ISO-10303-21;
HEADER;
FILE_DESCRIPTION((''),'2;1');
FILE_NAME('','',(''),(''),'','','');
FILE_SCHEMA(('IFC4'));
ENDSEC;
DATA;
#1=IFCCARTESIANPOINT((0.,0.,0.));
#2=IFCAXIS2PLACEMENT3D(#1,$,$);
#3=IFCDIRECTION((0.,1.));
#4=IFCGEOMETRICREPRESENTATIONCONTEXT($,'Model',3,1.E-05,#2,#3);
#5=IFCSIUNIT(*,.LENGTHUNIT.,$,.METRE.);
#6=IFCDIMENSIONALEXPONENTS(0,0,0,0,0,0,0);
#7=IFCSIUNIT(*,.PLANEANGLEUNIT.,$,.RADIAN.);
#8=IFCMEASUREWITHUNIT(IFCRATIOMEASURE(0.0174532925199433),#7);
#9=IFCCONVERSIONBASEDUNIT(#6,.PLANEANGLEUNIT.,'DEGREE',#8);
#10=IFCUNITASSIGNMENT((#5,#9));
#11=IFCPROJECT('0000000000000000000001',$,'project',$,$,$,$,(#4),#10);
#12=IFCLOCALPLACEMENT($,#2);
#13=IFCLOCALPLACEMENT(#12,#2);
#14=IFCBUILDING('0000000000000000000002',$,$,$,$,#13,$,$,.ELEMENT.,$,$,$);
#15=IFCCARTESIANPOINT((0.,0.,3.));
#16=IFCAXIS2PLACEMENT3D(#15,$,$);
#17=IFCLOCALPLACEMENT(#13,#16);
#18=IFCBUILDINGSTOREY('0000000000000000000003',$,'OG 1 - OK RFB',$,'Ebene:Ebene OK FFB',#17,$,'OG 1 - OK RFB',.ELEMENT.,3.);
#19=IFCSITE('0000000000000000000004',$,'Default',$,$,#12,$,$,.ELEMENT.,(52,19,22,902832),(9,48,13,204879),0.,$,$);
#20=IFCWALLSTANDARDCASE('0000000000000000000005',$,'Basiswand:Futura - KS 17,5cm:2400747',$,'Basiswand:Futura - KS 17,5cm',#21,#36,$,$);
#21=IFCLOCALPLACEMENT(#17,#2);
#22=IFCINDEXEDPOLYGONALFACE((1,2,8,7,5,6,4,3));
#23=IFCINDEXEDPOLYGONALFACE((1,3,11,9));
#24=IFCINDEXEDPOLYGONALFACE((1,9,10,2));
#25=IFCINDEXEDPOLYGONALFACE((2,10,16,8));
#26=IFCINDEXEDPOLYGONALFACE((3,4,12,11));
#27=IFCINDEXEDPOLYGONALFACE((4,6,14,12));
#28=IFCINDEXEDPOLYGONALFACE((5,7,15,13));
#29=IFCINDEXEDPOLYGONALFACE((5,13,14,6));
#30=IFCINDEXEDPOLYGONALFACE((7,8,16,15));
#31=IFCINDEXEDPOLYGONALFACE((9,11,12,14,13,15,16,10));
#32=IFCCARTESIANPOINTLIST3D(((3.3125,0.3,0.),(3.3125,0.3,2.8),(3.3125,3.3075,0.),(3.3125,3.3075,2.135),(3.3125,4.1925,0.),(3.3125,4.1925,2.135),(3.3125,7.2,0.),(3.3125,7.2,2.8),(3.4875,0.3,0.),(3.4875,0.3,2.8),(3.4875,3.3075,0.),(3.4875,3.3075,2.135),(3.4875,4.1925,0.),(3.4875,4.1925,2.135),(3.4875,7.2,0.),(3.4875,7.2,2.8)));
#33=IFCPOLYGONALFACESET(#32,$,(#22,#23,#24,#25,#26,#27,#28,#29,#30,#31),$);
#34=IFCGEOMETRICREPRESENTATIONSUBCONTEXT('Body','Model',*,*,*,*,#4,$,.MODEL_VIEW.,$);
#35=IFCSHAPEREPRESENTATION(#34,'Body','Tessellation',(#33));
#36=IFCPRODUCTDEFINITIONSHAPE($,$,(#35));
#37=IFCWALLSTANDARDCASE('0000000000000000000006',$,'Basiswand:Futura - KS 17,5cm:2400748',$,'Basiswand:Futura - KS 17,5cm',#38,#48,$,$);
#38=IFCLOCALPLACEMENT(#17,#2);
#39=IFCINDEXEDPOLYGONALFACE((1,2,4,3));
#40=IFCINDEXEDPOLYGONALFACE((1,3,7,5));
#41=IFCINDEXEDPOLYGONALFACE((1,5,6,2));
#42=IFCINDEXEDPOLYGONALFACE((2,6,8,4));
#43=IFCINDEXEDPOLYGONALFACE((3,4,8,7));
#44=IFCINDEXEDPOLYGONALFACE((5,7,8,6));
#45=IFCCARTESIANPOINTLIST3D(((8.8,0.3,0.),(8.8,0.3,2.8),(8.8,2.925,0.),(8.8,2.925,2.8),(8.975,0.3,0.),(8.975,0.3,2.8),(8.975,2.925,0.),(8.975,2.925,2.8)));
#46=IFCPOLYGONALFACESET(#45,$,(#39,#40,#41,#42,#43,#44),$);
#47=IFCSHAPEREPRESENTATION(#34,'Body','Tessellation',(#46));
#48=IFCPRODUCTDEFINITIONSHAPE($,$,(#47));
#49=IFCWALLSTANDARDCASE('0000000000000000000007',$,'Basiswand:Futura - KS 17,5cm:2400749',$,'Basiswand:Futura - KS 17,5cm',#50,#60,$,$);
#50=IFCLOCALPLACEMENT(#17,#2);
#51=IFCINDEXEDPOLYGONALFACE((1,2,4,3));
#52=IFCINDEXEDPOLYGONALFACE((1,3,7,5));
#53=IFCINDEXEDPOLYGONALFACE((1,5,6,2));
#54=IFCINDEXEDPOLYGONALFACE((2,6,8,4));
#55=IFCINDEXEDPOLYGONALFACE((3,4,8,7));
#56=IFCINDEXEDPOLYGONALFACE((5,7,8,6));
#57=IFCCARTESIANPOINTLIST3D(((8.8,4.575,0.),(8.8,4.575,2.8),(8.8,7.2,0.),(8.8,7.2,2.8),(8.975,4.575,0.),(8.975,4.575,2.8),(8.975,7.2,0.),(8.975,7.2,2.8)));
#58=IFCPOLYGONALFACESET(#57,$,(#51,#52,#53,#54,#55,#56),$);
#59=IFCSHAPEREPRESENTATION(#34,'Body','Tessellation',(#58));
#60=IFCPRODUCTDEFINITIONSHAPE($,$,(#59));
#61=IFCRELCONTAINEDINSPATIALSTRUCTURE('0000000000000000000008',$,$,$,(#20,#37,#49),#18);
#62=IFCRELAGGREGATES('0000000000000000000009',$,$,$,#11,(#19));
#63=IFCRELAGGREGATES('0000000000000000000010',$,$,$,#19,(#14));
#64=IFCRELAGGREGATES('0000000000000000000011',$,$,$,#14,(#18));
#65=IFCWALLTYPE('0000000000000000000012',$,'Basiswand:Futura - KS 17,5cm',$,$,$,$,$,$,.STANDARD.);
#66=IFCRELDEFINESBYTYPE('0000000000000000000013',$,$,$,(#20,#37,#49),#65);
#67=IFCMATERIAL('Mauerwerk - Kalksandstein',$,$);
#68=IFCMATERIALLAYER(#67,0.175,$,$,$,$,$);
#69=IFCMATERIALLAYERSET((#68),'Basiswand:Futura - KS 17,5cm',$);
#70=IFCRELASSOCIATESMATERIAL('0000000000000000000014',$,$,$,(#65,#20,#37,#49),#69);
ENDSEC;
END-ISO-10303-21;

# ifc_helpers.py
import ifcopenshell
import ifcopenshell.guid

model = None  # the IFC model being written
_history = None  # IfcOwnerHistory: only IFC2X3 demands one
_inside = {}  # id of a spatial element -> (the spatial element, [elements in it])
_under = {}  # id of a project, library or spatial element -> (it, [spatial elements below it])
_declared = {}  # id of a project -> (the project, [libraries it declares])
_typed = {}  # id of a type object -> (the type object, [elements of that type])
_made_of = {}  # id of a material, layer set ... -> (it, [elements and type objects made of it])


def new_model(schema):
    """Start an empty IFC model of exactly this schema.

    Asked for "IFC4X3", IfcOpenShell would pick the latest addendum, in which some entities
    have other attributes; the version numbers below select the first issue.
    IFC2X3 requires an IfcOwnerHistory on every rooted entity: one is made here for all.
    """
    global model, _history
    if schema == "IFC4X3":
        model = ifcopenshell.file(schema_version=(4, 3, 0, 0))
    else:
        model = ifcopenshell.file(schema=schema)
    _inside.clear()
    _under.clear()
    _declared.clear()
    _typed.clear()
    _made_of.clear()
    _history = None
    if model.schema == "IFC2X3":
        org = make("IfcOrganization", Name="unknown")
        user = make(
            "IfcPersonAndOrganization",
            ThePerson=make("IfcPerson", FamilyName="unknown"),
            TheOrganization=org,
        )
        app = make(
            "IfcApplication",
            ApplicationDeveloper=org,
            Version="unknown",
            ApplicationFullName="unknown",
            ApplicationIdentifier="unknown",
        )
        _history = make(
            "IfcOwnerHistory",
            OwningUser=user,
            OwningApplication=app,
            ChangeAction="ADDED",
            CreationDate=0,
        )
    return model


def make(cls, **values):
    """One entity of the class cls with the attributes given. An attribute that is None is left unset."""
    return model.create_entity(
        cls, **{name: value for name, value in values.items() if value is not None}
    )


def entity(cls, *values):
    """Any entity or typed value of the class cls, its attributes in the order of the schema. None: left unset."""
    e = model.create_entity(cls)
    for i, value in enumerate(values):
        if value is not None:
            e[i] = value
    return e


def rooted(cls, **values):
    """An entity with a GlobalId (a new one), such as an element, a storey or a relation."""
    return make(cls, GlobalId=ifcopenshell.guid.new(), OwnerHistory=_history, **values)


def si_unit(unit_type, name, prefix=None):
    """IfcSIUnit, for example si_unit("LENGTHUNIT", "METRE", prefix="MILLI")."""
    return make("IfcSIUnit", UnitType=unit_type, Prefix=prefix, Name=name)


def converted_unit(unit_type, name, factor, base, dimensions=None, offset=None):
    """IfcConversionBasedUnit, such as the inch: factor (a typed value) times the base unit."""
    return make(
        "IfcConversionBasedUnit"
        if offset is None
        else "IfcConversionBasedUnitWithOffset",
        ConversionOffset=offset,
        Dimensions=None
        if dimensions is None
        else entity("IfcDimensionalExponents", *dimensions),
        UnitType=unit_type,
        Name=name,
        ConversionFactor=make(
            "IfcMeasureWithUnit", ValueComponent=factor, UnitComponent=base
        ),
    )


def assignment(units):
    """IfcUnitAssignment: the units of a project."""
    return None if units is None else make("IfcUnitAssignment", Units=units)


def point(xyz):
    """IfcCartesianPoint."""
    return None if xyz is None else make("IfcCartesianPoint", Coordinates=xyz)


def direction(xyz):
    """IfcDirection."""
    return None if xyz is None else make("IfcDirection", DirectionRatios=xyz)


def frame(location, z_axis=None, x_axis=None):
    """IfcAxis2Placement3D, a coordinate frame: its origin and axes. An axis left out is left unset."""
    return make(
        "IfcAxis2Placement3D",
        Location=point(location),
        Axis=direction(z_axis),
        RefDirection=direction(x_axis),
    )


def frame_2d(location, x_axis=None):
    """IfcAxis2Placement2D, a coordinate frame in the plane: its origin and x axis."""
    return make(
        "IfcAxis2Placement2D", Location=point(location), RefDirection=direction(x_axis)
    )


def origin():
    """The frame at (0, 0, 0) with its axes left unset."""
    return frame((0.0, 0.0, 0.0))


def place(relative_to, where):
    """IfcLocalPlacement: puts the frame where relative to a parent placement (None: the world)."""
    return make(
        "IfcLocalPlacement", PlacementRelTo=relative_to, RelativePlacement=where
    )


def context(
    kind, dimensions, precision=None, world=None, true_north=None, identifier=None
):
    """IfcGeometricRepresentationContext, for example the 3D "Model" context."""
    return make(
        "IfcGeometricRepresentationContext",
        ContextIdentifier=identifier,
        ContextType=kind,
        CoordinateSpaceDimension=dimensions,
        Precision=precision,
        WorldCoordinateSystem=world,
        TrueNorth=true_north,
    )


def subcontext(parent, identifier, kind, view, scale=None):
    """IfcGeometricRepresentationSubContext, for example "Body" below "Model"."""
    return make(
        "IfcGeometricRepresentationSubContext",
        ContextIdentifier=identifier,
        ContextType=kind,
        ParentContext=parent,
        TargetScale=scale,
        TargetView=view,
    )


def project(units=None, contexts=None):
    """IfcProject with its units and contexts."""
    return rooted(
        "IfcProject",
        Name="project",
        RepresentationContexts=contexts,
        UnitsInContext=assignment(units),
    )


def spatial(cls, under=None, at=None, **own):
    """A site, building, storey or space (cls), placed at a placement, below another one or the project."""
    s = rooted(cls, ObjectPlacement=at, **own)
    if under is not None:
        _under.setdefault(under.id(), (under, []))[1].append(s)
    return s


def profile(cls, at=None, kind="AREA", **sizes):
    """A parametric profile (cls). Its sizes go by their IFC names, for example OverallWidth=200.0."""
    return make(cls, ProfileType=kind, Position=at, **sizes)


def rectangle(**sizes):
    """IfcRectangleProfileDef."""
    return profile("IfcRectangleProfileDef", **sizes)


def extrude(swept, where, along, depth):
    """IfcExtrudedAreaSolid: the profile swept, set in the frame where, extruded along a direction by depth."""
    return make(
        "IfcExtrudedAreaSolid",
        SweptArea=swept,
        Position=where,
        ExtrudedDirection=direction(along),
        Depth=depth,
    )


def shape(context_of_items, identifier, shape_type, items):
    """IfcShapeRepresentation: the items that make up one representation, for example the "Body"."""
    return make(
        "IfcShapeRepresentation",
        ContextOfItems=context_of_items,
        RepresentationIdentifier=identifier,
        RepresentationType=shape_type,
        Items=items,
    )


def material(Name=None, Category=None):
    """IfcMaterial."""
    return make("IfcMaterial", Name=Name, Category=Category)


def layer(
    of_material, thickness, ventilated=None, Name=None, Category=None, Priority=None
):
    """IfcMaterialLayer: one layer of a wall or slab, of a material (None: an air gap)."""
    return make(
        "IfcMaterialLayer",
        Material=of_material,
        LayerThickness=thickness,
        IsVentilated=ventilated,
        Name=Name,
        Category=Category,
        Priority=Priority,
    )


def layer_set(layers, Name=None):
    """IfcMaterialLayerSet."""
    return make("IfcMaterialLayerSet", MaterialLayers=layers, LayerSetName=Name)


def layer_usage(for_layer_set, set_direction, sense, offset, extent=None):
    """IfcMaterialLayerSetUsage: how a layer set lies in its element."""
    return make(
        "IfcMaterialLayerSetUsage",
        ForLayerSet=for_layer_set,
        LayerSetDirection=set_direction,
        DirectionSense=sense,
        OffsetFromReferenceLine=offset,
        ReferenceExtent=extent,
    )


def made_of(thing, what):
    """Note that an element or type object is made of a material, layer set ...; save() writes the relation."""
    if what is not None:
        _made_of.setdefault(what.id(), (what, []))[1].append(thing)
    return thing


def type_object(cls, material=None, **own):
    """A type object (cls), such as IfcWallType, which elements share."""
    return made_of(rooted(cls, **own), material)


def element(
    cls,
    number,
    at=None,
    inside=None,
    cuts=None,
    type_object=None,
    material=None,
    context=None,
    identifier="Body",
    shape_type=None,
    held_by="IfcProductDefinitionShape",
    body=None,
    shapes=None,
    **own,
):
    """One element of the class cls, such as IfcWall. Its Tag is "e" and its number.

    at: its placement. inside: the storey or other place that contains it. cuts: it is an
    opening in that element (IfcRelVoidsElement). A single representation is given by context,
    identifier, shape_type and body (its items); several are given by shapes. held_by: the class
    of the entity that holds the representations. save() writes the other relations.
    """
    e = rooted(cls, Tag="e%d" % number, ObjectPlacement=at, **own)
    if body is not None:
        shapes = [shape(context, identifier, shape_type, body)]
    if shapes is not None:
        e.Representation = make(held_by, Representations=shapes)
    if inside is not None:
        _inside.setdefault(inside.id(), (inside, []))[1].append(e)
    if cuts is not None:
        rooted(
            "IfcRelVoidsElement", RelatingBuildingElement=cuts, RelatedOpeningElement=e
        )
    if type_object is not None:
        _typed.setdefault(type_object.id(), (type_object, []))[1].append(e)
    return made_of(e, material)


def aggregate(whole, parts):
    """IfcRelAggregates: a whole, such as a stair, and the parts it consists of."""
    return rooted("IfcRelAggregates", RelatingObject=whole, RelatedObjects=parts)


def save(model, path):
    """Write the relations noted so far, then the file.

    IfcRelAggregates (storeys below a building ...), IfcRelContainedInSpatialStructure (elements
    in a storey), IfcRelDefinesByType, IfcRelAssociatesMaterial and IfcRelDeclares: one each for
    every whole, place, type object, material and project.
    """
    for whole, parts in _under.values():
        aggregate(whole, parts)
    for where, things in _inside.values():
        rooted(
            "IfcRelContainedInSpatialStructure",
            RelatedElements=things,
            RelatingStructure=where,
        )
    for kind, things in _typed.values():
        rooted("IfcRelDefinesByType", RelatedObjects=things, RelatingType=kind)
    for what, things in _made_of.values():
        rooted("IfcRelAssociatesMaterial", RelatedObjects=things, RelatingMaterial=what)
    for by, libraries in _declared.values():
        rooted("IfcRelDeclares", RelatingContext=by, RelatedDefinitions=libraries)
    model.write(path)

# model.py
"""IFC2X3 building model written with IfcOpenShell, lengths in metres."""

from ifc_helpers import new_model, entity, si_unit, converted_unit, direction, frame, frame_2d, origin, place, context, subcontext, project, spatial, rectangle, extrude, material, layer, layer_set, layer_usage, type_object, element, save


model = new_model("IFC2X3")

# Units and contexts
model_context = context("Model", 3, precision=1e-05, world=origin(), true_north=direction((0.0, 1.0)))
body_context = subcontext(model_context, "Body", "Model", "MODEL_VIEW")
ifc_project = project(units=[si_unit("LENGTHUNIT", "METRE"), converted_unit("PLANEANGLEUNIT", "DEGREE", entity("IfcRatioMeasure", 0.0174532925199433), si_unit("PLANEANGLEUNIT", "RADIAN"), dimensions=[0, 0, 0, 0, 0, 0, 0])], contexts=[model_context])

# Site, building, storey
site_placement = place(None, frame((0.0, 0.0, 0.0)))
site = spatial("IfcSite", under=ifc_project, at=site_placement, Name="Default", CompositionType="ELEMENT", RefLatitude=(52, 19, 22, 902832), RefLongitude=(9, 48, 13, 204879), RefElevation=0.0)
building_placement = place(site_placement, origin())
building = spatial("IfcBuilding", under=site, at=building_placement, CompositionType="ELEMENT")
storey_placement = place(building_placement, frame((0.0, 0.0, 3.0)))
storey = spatial("IfcBuildingStorey", under=building, at=storey_placement, Name="OG 1 - OK RFB", ObjectType="Ebene:Ebene OK FFB", LongName="OG 1 - OK RFB", CompositionType="ELEMENT", Elevation=3.0)

# Shared definitions
ifc_material = material(Name="Mauerwerk - Kalksandstein")
ifc_layer = layer(ifc_material, 0.175)
ifc_layer_set = layer_set([ifc_layer], Name="Basiswand:Futura - KS 17,5cm")
wall_type = type_object("IfcWallType", Name="Basiswand:Futura - KS 17,5cm", PredefinedType="STANDARD", material=ifc_layer_set)

# Wall, opening
ifc_layer_usage_1 = layer_usage(ifc_layer_set, "AXIS2", "NEGATIVE", 0.0875)
wall_1_placement = place(storey_placement, frame((3.4, 0.3, 0.0), z_axis=(0.0, 0.0, 1.0), x_axis=(0.0, 1.0, 0.0)))
wall_1 = element("IfcWallStandardCase", 1, at=wall_1_placement, inside=storey, type_object=wall_type, material=ifc_layer_usage_1, Name="Basiswand:Futura - KS 17,5cm:2400747", ObjectType="Basiswand:Futura - KS 17,5cm", context=body_context, shape_type="SweptSolid", body=[
    extrude(rectangle(XDim=6.9, YDim=0.175, at=frame_2d((3.45, 0.0), x_axis=(-1.0, 0.0))), origin(), (0.0, 0.0, 1.0), 2.8),
])
opening_1_placement = place(wall_1_placement, frame((3.8925, 0.0875, -0.18)))
element("IfcOpeningElement", 2, at=opening_1_placement, cuts=wall_1, ObjectType="Opening", context=body_context, shape_type="SweptSolid", body=[
    extrude(rectangle(XDim=2.315, YDim=0.885, at=frame_2d((1.1575, 0.4425), x_axis=(-1.0, 0.0))), frame((0.0, 0.0, 0.0), z_axis=(0.0, -1.0, 0.0), x_axis=(0.0, 0.0, 1.0)), (0.0, 0.0, 1.0), 0.175),
])

# Walls
ifc_layer_usage_2 = layer_usage(ifc_layer_set, "AXIS2", "NEGATIVE", 0.0875)
wall_2_placement = place(storey_placement, frame((8.8875, 0.3, 0.0), z_axis=(0.0, 0.0, 1.0), x_axis=(0.0, 1.0, 0.0)))
element("IfcWallStandardCase", 3, at=wall_2_placement, inside=storey, type_object=wall_type, material=ifc_layer_usage_2, Name="Basiswand:Futura - KS 17,5cm:2400748", ObjectType="Basiswand:Futura - KS 17,5cm", context=body_context, shape_type="SweptSolid", body=[
    extrude(rectangle(XDim=2.625, YDim=0.175, at=frame_2d((1.3125, 0.0), x_axis=(-1.0, 0.0))), origin(), (0.0, 0.0, 1.0), 2.8),
])
ifc_layer_usage_3 = layer_usage(ifc_layer_set, "AXIS2", "NEGATIVE", 0.0875)
wall_3_placement = place(storey_placement, frame((8.8875, 4.575, 0.0), z_axis=(0.0, 0.0, 1.0), x_axis=(0.0, 1.0, 0.0)))
element("IfcWallStandardCase", 4, at=wall_3_placement, inside=storey, type_object=wall_type, material=ifc_layer_usage_3, Name="Basiswand:Futura - KS 17,5cm:2400749", ObjectType="Basiswand:Futura - KS 17,5cm", context=body_context, shape_type="SweptSolid", body=[
    extrude(rectangle(XDim=2.625, YDim=0.175, at=frame_2d((1.3125, 0.0), x_axis=(-1.0, 0.0))), origin(), (0.0, 0.0, 1.0), 2.8),
])

save(model, "model.ifc")
